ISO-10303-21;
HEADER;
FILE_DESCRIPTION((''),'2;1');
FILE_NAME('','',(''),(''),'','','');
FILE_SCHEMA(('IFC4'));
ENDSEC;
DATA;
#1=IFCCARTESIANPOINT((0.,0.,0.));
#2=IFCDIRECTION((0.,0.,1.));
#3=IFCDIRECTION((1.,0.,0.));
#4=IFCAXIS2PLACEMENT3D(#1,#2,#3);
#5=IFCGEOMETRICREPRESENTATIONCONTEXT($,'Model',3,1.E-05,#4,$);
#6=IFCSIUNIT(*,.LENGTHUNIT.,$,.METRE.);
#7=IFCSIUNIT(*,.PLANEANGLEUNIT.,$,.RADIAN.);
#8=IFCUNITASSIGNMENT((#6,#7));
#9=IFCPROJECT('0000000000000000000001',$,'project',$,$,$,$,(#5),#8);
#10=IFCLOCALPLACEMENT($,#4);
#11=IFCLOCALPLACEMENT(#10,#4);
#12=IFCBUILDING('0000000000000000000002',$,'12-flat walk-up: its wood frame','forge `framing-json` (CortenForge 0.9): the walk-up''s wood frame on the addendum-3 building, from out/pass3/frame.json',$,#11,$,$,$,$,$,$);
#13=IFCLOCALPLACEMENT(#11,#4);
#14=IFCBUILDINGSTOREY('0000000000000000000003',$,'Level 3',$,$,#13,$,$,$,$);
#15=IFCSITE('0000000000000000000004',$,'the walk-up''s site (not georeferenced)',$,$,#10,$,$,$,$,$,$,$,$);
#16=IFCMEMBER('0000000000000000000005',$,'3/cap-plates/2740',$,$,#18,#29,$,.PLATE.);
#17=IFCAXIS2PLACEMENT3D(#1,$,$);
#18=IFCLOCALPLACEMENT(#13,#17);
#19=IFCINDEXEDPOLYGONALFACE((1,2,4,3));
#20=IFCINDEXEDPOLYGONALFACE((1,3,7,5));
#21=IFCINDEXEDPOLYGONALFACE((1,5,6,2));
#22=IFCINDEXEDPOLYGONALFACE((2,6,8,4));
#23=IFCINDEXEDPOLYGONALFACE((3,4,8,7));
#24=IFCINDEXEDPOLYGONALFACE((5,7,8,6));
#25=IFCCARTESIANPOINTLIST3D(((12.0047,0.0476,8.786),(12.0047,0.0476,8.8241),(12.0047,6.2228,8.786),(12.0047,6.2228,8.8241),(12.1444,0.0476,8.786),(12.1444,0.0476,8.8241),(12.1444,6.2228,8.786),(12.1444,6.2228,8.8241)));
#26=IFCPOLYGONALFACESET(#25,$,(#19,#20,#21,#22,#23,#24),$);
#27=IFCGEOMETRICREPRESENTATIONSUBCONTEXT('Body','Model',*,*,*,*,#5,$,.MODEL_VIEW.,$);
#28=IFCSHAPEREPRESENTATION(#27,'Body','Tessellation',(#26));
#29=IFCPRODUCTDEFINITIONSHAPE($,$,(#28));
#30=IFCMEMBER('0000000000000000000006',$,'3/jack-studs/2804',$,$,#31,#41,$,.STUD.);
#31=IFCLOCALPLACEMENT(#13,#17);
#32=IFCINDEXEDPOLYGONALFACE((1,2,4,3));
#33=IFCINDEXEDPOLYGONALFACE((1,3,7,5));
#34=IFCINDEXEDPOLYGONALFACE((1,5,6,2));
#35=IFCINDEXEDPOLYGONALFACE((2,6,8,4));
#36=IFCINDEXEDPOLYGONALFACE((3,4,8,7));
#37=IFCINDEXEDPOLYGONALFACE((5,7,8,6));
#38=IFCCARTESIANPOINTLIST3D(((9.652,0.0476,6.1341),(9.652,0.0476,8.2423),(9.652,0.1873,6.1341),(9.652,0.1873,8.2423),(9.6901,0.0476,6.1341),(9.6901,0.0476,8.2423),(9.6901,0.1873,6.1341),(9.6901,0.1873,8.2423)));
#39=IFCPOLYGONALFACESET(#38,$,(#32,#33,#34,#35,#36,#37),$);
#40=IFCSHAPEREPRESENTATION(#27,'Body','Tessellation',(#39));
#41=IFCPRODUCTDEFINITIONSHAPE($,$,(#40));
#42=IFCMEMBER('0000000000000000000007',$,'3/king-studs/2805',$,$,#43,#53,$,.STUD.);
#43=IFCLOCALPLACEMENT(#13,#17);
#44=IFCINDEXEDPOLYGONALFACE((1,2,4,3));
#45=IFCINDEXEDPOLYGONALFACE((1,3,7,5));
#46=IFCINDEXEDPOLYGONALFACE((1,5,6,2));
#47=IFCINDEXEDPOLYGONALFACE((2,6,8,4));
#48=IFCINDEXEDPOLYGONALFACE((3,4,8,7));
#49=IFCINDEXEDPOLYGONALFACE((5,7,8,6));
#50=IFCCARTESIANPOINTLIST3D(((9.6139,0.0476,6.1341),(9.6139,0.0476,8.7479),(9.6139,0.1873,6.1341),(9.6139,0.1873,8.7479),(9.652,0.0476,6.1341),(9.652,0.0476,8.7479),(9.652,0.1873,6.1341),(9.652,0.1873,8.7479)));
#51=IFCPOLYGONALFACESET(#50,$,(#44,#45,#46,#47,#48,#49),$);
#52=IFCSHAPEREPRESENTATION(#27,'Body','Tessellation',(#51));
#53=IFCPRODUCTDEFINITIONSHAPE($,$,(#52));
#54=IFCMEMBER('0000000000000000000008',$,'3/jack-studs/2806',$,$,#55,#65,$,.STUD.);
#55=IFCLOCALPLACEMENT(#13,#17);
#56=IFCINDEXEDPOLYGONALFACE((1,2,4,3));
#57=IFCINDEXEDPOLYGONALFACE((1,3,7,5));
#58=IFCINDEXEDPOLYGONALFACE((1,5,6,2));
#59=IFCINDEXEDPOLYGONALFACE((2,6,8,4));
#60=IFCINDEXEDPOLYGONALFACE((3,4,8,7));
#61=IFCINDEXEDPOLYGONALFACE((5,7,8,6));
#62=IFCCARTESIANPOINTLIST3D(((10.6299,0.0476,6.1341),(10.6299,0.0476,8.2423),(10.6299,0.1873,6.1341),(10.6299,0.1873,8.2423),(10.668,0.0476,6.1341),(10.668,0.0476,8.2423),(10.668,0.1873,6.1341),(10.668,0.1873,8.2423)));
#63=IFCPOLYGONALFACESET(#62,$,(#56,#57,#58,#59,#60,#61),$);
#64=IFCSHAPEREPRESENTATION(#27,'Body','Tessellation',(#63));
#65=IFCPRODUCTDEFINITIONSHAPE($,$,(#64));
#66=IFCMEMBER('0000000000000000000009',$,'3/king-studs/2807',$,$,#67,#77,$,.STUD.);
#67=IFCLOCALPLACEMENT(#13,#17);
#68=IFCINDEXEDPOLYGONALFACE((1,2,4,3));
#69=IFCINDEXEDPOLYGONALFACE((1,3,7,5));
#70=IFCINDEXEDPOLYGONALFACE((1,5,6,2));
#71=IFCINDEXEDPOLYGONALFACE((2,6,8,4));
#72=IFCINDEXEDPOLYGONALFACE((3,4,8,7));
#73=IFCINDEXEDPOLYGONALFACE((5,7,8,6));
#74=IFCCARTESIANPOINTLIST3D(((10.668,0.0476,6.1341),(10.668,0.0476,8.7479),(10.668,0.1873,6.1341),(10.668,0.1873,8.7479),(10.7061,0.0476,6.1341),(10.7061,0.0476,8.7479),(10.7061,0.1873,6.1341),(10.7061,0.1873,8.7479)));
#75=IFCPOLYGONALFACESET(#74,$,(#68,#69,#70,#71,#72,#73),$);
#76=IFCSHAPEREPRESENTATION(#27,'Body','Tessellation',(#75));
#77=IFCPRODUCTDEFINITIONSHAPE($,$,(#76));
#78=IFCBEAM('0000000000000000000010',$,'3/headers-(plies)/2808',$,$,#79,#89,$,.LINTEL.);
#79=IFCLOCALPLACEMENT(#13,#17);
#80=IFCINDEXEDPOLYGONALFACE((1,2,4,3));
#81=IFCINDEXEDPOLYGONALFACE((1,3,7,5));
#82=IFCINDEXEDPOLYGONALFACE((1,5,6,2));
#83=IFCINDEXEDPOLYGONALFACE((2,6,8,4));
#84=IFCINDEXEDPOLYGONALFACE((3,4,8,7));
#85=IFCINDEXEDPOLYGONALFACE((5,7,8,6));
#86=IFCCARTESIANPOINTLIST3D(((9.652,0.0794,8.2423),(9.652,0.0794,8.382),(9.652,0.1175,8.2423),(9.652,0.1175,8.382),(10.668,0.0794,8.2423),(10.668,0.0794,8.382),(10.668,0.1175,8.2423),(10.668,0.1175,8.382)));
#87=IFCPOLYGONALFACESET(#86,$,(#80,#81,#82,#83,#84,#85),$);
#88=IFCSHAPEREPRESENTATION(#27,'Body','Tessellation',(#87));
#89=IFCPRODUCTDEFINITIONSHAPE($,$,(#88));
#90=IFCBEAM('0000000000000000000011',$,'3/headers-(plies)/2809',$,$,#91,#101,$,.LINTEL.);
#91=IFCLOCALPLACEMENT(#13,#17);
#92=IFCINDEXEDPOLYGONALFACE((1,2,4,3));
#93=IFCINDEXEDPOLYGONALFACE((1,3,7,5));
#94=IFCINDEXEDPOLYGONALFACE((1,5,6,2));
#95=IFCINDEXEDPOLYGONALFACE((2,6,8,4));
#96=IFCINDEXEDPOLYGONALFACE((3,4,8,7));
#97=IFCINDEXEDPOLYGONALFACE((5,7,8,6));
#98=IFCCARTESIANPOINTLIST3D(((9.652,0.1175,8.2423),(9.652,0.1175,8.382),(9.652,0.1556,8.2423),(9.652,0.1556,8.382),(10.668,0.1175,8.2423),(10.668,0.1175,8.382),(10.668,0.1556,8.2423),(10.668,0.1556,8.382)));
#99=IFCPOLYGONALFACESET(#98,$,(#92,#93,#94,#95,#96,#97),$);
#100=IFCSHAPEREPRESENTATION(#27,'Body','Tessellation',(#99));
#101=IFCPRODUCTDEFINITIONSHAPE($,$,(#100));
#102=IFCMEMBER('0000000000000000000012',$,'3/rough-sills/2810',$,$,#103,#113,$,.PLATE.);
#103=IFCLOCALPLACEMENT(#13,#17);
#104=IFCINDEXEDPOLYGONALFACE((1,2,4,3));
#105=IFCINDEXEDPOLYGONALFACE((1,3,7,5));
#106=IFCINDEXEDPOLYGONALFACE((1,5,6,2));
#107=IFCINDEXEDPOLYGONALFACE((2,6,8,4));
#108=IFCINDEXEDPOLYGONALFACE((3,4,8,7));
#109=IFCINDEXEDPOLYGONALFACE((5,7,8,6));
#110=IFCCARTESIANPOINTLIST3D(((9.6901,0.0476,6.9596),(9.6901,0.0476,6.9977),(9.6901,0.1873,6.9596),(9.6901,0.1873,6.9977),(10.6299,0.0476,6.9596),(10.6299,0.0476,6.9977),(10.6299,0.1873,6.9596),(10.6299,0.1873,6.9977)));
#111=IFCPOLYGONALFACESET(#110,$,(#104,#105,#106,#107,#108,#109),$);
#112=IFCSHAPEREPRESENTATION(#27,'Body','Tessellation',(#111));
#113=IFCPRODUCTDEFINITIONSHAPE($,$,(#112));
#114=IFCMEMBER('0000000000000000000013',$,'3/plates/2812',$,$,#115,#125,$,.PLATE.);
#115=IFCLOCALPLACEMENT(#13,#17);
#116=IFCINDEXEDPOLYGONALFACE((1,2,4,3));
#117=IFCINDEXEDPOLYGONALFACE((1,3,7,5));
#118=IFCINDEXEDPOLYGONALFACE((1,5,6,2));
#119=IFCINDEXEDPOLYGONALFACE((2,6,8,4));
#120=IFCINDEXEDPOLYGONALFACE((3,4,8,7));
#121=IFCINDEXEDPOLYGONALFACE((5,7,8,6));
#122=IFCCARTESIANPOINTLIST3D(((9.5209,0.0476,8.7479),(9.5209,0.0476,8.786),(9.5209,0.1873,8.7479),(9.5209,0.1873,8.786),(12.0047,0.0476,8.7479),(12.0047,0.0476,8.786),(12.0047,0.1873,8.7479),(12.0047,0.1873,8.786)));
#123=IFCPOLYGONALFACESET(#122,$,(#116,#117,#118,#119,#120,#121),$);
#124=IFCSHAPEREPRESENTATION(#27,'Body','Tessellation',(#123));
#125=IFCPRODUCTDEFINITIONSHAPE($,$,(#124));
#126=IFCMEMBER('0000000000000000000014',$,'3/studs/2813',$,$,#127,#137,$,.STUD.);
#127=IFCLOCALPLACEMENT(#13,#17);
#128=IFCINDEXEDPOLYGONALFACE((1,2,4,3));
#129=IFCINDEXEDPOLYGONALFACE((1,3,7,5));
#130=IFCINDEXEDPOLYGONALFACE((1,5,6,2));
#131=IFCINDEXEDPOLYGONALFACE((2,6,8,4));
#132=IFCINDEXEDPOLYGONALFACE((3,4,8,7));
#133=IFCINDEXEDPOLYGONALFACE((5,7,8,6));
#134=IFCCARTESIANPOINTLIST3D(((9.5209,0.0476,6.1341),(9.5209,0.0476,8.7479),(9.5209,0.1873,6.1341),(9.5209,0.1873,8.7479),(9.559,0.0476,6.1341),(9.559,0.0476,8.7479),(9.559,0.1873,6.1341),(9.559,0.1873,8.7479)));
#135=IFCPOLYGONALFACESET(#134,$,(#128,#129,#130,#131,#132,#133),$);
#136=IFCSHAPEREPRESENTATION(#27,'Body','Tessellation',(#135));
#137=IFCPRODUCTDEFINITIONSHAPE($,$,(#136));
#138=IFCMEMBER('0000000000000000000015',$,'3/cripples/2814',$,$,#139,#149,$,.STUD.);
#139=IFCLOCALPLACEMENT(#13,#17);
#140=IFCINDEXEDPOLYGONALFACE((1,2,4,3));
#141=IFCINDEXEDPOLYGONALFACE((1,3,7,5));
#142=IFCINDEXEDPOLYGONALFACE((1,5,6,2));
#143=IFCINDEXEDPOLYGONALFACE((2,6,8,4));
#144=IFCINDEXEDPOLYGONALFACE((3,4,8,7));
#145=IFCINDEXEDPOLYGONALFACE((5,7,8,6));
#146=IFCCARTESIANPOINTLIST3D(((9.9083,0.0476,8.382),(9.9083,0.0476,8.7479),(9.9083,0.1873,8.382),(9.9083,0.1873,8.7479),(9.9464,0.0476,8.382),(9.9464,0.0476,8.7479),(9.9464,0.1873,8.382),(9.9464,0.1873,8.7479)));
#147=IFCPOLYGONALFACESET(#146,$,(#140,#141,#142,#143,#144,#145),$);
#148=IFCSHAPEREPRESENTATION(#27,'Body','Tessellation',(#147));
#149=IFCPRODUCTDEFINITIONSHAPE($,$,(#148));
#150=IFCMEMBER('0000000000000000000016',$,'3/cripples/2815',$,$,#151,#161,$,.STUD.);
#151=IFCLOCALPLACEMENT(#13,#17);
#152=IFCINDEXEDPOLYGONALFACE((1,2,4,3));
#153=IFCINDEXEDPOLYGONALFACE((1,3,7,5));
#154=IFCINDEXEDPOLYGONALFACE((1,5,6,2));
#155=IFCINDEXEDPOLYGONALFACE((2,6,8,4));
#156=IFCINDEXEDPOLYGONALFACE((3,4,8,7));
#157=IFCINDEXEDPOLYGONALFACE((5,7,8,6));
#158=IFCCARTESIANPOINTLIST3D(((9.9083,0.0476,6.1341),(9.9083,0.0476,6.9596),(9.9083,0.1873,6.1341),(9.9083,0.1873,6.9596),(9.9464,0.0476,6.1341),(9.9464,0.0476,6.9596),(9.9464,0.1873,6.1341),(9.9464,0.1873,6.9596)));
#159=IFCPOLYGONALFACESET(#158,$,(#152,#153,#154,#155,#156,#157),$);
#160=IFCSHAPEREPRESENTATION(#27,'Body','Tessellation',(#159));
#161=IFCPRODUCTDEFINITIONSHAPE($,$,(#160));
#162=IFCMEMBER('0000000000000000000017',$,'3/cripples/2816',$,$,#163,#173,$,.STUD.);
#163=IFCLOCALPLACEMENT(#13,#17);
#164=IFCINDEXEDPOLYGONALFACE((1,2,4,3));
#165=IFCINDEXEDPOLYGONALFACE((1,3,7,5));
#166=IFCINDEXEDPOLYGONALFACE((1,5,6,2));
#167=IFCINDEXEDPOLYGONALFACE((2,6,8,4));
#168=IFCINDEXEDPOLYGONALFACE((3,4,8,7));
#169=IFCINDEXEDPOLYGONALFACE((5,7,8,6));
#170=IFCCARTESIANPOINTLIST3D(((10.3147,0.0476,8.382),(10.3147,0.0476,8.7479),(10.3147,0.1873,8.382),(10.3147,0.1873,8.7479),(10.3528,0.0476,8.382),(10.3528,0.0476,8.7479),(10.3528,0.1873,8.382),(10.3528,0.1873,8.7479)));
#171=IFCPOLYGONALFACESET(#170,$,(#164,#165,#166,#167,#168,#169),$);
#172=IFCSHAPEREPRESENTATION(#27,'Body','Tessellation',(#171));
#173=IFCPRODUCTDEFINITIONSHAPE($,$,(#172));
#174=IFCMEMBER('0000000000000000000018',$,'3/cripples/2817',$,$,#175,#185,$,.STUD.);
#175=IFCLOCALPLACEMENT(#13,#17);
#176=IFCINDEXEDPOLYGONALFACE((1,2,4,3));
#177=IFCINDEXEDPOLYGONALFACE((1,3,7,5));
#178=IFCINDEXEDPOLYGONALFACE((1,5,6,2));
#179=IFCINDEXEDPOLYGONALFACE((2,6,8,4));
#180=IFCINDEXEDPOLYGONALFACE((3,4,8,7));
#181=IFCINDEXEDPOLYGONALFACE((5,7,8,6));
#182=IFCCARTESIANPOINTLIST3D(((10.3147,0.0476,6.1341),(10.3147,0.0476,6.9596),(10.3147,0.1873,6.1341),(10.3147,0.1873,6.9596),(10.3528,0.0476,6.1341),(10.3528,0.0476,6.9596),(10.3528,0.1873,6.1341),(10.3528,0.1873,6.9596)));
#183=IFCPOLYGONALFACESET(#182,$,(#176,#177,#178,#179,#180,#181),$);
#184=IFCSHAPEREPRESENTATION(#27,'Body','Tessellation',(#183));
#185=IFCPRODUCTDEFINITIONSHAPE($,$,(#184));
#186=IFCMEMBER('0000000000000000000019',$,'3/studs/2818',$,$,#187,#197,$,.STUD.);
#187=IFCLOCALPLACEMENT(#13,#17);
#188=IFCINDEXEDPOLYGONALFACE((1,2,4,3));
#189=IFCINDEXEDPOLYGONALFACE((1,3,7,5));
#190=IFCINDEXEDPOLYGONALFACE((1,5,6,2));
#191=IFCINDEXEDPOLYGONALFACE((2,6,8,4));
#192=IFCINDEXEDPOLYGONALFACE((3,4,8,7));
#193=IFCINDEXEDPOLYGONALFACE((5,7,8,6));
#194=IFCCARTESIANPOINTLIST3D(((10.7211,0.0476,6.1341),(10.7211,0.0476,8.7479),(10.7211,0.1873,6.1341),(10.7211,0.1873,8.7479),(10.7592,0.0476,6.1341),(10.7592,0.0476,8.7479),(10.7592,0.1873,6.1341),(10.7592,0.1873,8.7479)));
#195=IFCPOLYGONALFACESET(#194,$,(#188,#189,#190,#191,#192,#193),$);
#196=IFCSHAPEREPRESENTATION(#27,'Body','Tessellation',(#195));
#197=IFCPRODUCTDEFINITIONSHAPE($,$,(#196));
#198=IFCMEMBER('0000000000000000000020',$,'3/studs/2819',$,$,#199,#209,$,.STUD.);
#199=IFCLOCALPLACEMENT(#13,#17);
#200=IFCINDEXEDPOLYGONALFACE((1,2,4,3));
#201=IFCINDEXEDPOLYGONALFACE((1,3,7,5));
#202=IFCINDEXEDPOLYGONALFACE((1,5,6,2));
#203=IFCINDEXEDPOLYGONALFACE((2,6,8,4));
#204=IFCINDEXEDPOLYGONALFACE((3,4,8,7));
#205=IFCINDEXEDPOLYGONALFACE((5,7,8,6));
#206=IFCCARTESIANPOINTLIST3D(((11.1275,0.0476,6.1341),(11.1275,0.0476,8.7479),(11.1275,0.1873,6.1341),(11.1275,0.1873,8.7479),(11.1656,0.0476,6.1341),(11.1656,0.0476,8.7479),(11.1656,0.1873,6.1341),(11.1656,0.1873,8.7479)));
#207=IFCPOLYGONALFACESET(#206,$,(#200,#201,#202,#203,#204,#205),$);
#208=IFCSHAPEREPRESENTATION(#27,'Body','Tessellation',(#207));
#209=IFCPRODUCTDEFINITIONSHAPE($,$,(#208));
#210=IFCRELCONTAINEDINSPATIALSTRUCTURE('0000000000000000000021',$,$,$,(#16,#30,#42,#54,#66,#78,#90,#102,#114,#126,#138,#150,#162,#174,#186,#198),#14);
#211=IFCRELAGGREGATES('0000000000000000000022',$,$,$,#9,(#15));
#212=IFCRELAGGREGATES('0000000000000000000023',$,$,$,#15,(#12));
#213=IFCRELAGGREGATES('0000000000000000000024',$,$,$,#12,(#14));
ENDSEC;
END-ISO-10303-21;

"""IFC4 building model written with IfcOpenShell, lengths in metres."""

from ifc_helpers import new_model, si_unit, frame, frame_2d, origin, origin_with_axes, place, context, subcontext, project, spatial, rectangle, extrude, element, save


model = new_model("IFC4")

# Units and contexts
model_context = context("Model", 3, precision=1e-05, world=origin_with_axes())
body_context = subcontext(model_context, "Body", "Model", "MODEL_VIEW")
ifc_project = project(units=[si_unit("LENGTHUNIT", "METRE"), si_unit("PLANEANGLEUNIT", "RADIAN")], contexts=[model_context])

# Site, building, storey
site_placement = place(None, origin_with_axes())
site = spatial("IfcSite", under=ifc_project, at=site_placement, Name="the walk-up's site (not georeferenced)")
building_placement = place(site_placement, origin_with_axes())
building = spatial("IfcBuilding", under=site, at=building_placement, Name="12-flat walk-up: its wood frame", Description="forge `framing-json` (CortenForge 0.9): the walk-up's wood frame on the addendum-3 building, from out/pass3/frame.json")
storey_placement = place(building_placement, origin_with_axes())
storey = spatial("IfcBuildingStorey", under=building, at=storey_placement, Name="Level 3")

# Members
member_1_placement = place(storey_placement, frame((12.0047, 0.0476, 8.786), z_axis=(0.0, 0.0, 1.0), x_axis=(1.0, 0.0, 0.0)))
element("IfcMember", 1, at=member_1_placement, inside=storey, Name="3/cap-plates/2740", PredefinedType="PLATE", context=body_context, shape_type="SweptSolid", body=[
    extrude(rectangle(XDim=0.1397, YDim=6.1752, at=frame_2d((0.0698, 3.0876))), origin(), (0.0, 0.0, 1.0), 0.0381),
])
member_2_placement = place(storey_placement, frame((9.652, 0.0476, 6.1341), z_axis=(0.0, 0.0, 1.0), x_axis=(1.0, 0.0, 0.0)))
element("IfcMember", 2, at=member_2_placement, inside=storey, Name="3/jack-studs/2804", PredefinedType="STUD", context=body_context, shape_type="SweptSolid", body=[
    extrude(rectangle(XDim=0.0381, YDim=0.1397, at=frame_2d((0.0191, 0.0698))), origin(), (0.0, 0.0, 1.0), 2.1082),
])
member_3_placement = place(storey_placement, frame((9.6139, 0.0476, 6.1341), z_axis=(0.0, 0.0, 1.0), x_axis=(1.0, 0.0, 0.0)))
element("IfcMember", 3, at=member_3_placement, inside=storey, Name="3/king-studs/2805", PredefinedType="STUD", context=body_context, shape_type="SweptSolid", body=[
    extrude(rectangle(XDim=0.0381, YDim=0.1397, at=frame_2d((0.0191, 0.0698))), origin(), (0.0, 0.0, 1.0), 2.6138),
])
member_4_placement = place(storey_placement, frame((10.6299, 0.0476, 6.1341), z_axis=(0.0, 0.0, 1.0), x_axis=(1.0, 0.0, 0.0)))
element("IfcMember", 4, at=member_4_placement, inside=storey, Name="3/jack-studs/2806", PredefinedType="STUD", context=body_context, shape_type="SweptSolid", body=[
    extrude(rectangle(XDim=0.0381, YDim=0.1397, at=frame_2d((0.0191, 0.0698))), origin(), (0.0, 0.0, 1.0), 2.1082),
])
member_5_placement = place(storey_placement, frame((10.668, 0.0476, 6.1341), z_axis=(0.0, 0.0, 1.0), x_axis=(1.0, 0.0, 0.0)))
element("IfcMember", 5, at=member_5_placement, inside=storey, Name="3/king-studs/2807", PredefinedType="STUD", context=body_context, shape_type="SweptSolid", body=[
    extrude(rectangle(XDim=0.0381, YDim=0.1397, at=frame_2d((0.0191, 0.0698))), origin(), (0.0, 0.0, 1.0), 2.6138),
])

# Beams
for number, where, z_axis, x_axis, name in (
    (6, (9.652, 0.0794, 8.2423), (0.0, 0.0, 1.0), (1.0, 0.0, 0.0), "3/headers-(plies)/2808"),
    (7, (9.652, 0.1175, 8.2423), (0.0, 0.0, 1.0), (1.0, 0.0, 0.0), "3/headers-(plies)/2809"),
):
    element("IfcBeam", number, at=place(storey_placement, frame(where, z_axis=z_axis, x_axis=x_axis)), inside=storey, Name=name, PredefinedType="LINTEL", context=body_context, shape_type="SweptSolid", body=[
        extrude(rectangle(XDim=1.016, YDim=0.0381, at=frame_2d((0.508, 0.019))), origin(), (0.0, 0.0, 1.0), 0.1397),
    ])

# Members
member_6_placement = place(storey_placement, frame((9.6901, 0.0476, 6.9596), z_axis=(0.0, 0.0, 1.0), x_axis=(1.0, 0.0, 0.0)))
element("IfcMember", 8, at=member_6_placement, inside=storey, Name="3/rough-sills/2810", PredefinedType="PLATE", context=body_context, shape_type="SweptSolid", body=[
    extrude(rectangle(XDim=0.9398, YDim=0.1397, at=frame_2d((0.4699, 0.0698))), origin(), (0.0, 0.0, 1.0), 0.0381),
])
member_7_placement = place(storey_placement, frame((9.5209, 0.0476, 8.7479), z_axis=(0.0, 0.0, 1.0), x_axis=(1.0, 0.0, 0.0)))
element("IfcMember", 9, at=member_7_placement, inside=storey, Name="3/plates/2812", PredefinedType="PLATE", context=body_context, shape_type="SweptSolid", body=[
    extrude(rectangle(XDim=2.4838, YDim=0.1397, at=frame_2d((1.2419, 0.0698))), origin(), (0.0, 0.0, 1.0), 0.0381),
])
member_8_placement = place(storey_placement, frame((9.5209, 0.0476, 6.1341), z_axis=(0.0, 0.0, 1.0), x_axis=(1.0, 0.0, 0.0)))
element("IfcMember", 10, at=member_8_placement, inside=storey, Name="3/studs/2813", PredefinedType="STUD", context=body_context, shape_type="SweptSolid", body=[
    extrude(rectangle(XDim=0.0381, YDim=0.1397, at=frame_2d((0.0191, 0.0698))), origin(), (0.0, 0.0, 1.0), 2.6138),
])
member_9_placement = place(storey_placement, frame((9.9083, 0.0476, 8.382), z_axis=(0.0, 0.0, 1.0), x_axis=(1.0, 0.0, 0.0)))
element("IfcMember", 11, at=member_9_placement, inside=storey, Name="3/cripples/2814", PredefinedType="STUD", context=body_context, shape_type="SweptSolid", body=[
    extrude(rectangle(XDim=0.0381, YDim=0.1397, at=frame_2d((0.0191, 0.0698))), origin(), (0.0, 0.0, 1.0), 0.3659),
])
member_10_placement = place(storey_placement, frame((9.9083, 0.0476, 6.1341), z_axis=(0.0, 0.0, 1.0), x_axis=(1.0, 0.0, 0.0)))
element("IfcMember", 12, at=member_10_placement, inside=storey, Name="3/cripples/2815", PredefinedType="STUD", context=body_context, shape_type="SweptSolid", body=[
    extrude(rectangle(XDim=0.0381, YDim=0.1397, at=frame_2d((0.0191, 0.0698))), origin(), (0.0, 0.0, 1.0), 0.8255),
])
member_11_placement = place(storey_placement, frame((10.3147, 0.0476, 8.382), z_axis=(0.0, 0.0, 1.0), x_axis=(1.0, 0.0, 0.0)))
element("IfcMember", 13, at=member_11_placement, inside=storey, Name="3/cripples/2816", PredefinedType="STUD", context=body_context, shape_type="SweptSolid", body=[
    extrude(rectangle(XDim=0.0381, YDim=0.1397, at=frame_2d((0.0191, 0.0698))), origin(), (0.0, 0.0, 1.0), 0.3659),
])
member_12_placement = place(storey_placement, frame((10.3147, 0.0476, 6.1341), z_axis=(0.0, 0.0, 1.0), x_axis=(1.0, 0.0, 0.0)))
element("IfcMember", 14, at=member_12_placement, inside=storey, Name="3/cripples/2817", PredefinedType="STUD", context=body_context, shape_type="SweptSolid", body=[
    extrude(rectangle(XDim=0.0381, YDim=0.1397, at=frame_2d((0.0191, 0.0698))), origin(), (0.0, 0.0, 1.0), 0.8255),
])
for number, where, z_axis, x_axis, name in (
    (15, (10.7211, 0.0476, 6.1341), (0.0, 0.0, 1.0), (1.0, 0.0, 0.0), "3/studs/2818"),
    (16, (11.1275, 0.0476, 6.1341), (0.0, 0.0, 1.0), (1.0, 0.0, 0.0), "3/studs/2819"),
):
    element("IfcMember", number, at=place(storey_placement, frame(where, z_axis=z_axis, x_axis=x_axis)), inside=storey, Name=name, PredefinedType="STUD", context=body_context, shape_type="SweptSolid", body=[
        extrude(rectangle(XDim=0.0381, YDim=0.1397, at=frame_2d((0.0191, 0.0698))), origin(), (0.0, 0.0, 1.0), 2.6138),
    ])

save(model, "model.ifc")
